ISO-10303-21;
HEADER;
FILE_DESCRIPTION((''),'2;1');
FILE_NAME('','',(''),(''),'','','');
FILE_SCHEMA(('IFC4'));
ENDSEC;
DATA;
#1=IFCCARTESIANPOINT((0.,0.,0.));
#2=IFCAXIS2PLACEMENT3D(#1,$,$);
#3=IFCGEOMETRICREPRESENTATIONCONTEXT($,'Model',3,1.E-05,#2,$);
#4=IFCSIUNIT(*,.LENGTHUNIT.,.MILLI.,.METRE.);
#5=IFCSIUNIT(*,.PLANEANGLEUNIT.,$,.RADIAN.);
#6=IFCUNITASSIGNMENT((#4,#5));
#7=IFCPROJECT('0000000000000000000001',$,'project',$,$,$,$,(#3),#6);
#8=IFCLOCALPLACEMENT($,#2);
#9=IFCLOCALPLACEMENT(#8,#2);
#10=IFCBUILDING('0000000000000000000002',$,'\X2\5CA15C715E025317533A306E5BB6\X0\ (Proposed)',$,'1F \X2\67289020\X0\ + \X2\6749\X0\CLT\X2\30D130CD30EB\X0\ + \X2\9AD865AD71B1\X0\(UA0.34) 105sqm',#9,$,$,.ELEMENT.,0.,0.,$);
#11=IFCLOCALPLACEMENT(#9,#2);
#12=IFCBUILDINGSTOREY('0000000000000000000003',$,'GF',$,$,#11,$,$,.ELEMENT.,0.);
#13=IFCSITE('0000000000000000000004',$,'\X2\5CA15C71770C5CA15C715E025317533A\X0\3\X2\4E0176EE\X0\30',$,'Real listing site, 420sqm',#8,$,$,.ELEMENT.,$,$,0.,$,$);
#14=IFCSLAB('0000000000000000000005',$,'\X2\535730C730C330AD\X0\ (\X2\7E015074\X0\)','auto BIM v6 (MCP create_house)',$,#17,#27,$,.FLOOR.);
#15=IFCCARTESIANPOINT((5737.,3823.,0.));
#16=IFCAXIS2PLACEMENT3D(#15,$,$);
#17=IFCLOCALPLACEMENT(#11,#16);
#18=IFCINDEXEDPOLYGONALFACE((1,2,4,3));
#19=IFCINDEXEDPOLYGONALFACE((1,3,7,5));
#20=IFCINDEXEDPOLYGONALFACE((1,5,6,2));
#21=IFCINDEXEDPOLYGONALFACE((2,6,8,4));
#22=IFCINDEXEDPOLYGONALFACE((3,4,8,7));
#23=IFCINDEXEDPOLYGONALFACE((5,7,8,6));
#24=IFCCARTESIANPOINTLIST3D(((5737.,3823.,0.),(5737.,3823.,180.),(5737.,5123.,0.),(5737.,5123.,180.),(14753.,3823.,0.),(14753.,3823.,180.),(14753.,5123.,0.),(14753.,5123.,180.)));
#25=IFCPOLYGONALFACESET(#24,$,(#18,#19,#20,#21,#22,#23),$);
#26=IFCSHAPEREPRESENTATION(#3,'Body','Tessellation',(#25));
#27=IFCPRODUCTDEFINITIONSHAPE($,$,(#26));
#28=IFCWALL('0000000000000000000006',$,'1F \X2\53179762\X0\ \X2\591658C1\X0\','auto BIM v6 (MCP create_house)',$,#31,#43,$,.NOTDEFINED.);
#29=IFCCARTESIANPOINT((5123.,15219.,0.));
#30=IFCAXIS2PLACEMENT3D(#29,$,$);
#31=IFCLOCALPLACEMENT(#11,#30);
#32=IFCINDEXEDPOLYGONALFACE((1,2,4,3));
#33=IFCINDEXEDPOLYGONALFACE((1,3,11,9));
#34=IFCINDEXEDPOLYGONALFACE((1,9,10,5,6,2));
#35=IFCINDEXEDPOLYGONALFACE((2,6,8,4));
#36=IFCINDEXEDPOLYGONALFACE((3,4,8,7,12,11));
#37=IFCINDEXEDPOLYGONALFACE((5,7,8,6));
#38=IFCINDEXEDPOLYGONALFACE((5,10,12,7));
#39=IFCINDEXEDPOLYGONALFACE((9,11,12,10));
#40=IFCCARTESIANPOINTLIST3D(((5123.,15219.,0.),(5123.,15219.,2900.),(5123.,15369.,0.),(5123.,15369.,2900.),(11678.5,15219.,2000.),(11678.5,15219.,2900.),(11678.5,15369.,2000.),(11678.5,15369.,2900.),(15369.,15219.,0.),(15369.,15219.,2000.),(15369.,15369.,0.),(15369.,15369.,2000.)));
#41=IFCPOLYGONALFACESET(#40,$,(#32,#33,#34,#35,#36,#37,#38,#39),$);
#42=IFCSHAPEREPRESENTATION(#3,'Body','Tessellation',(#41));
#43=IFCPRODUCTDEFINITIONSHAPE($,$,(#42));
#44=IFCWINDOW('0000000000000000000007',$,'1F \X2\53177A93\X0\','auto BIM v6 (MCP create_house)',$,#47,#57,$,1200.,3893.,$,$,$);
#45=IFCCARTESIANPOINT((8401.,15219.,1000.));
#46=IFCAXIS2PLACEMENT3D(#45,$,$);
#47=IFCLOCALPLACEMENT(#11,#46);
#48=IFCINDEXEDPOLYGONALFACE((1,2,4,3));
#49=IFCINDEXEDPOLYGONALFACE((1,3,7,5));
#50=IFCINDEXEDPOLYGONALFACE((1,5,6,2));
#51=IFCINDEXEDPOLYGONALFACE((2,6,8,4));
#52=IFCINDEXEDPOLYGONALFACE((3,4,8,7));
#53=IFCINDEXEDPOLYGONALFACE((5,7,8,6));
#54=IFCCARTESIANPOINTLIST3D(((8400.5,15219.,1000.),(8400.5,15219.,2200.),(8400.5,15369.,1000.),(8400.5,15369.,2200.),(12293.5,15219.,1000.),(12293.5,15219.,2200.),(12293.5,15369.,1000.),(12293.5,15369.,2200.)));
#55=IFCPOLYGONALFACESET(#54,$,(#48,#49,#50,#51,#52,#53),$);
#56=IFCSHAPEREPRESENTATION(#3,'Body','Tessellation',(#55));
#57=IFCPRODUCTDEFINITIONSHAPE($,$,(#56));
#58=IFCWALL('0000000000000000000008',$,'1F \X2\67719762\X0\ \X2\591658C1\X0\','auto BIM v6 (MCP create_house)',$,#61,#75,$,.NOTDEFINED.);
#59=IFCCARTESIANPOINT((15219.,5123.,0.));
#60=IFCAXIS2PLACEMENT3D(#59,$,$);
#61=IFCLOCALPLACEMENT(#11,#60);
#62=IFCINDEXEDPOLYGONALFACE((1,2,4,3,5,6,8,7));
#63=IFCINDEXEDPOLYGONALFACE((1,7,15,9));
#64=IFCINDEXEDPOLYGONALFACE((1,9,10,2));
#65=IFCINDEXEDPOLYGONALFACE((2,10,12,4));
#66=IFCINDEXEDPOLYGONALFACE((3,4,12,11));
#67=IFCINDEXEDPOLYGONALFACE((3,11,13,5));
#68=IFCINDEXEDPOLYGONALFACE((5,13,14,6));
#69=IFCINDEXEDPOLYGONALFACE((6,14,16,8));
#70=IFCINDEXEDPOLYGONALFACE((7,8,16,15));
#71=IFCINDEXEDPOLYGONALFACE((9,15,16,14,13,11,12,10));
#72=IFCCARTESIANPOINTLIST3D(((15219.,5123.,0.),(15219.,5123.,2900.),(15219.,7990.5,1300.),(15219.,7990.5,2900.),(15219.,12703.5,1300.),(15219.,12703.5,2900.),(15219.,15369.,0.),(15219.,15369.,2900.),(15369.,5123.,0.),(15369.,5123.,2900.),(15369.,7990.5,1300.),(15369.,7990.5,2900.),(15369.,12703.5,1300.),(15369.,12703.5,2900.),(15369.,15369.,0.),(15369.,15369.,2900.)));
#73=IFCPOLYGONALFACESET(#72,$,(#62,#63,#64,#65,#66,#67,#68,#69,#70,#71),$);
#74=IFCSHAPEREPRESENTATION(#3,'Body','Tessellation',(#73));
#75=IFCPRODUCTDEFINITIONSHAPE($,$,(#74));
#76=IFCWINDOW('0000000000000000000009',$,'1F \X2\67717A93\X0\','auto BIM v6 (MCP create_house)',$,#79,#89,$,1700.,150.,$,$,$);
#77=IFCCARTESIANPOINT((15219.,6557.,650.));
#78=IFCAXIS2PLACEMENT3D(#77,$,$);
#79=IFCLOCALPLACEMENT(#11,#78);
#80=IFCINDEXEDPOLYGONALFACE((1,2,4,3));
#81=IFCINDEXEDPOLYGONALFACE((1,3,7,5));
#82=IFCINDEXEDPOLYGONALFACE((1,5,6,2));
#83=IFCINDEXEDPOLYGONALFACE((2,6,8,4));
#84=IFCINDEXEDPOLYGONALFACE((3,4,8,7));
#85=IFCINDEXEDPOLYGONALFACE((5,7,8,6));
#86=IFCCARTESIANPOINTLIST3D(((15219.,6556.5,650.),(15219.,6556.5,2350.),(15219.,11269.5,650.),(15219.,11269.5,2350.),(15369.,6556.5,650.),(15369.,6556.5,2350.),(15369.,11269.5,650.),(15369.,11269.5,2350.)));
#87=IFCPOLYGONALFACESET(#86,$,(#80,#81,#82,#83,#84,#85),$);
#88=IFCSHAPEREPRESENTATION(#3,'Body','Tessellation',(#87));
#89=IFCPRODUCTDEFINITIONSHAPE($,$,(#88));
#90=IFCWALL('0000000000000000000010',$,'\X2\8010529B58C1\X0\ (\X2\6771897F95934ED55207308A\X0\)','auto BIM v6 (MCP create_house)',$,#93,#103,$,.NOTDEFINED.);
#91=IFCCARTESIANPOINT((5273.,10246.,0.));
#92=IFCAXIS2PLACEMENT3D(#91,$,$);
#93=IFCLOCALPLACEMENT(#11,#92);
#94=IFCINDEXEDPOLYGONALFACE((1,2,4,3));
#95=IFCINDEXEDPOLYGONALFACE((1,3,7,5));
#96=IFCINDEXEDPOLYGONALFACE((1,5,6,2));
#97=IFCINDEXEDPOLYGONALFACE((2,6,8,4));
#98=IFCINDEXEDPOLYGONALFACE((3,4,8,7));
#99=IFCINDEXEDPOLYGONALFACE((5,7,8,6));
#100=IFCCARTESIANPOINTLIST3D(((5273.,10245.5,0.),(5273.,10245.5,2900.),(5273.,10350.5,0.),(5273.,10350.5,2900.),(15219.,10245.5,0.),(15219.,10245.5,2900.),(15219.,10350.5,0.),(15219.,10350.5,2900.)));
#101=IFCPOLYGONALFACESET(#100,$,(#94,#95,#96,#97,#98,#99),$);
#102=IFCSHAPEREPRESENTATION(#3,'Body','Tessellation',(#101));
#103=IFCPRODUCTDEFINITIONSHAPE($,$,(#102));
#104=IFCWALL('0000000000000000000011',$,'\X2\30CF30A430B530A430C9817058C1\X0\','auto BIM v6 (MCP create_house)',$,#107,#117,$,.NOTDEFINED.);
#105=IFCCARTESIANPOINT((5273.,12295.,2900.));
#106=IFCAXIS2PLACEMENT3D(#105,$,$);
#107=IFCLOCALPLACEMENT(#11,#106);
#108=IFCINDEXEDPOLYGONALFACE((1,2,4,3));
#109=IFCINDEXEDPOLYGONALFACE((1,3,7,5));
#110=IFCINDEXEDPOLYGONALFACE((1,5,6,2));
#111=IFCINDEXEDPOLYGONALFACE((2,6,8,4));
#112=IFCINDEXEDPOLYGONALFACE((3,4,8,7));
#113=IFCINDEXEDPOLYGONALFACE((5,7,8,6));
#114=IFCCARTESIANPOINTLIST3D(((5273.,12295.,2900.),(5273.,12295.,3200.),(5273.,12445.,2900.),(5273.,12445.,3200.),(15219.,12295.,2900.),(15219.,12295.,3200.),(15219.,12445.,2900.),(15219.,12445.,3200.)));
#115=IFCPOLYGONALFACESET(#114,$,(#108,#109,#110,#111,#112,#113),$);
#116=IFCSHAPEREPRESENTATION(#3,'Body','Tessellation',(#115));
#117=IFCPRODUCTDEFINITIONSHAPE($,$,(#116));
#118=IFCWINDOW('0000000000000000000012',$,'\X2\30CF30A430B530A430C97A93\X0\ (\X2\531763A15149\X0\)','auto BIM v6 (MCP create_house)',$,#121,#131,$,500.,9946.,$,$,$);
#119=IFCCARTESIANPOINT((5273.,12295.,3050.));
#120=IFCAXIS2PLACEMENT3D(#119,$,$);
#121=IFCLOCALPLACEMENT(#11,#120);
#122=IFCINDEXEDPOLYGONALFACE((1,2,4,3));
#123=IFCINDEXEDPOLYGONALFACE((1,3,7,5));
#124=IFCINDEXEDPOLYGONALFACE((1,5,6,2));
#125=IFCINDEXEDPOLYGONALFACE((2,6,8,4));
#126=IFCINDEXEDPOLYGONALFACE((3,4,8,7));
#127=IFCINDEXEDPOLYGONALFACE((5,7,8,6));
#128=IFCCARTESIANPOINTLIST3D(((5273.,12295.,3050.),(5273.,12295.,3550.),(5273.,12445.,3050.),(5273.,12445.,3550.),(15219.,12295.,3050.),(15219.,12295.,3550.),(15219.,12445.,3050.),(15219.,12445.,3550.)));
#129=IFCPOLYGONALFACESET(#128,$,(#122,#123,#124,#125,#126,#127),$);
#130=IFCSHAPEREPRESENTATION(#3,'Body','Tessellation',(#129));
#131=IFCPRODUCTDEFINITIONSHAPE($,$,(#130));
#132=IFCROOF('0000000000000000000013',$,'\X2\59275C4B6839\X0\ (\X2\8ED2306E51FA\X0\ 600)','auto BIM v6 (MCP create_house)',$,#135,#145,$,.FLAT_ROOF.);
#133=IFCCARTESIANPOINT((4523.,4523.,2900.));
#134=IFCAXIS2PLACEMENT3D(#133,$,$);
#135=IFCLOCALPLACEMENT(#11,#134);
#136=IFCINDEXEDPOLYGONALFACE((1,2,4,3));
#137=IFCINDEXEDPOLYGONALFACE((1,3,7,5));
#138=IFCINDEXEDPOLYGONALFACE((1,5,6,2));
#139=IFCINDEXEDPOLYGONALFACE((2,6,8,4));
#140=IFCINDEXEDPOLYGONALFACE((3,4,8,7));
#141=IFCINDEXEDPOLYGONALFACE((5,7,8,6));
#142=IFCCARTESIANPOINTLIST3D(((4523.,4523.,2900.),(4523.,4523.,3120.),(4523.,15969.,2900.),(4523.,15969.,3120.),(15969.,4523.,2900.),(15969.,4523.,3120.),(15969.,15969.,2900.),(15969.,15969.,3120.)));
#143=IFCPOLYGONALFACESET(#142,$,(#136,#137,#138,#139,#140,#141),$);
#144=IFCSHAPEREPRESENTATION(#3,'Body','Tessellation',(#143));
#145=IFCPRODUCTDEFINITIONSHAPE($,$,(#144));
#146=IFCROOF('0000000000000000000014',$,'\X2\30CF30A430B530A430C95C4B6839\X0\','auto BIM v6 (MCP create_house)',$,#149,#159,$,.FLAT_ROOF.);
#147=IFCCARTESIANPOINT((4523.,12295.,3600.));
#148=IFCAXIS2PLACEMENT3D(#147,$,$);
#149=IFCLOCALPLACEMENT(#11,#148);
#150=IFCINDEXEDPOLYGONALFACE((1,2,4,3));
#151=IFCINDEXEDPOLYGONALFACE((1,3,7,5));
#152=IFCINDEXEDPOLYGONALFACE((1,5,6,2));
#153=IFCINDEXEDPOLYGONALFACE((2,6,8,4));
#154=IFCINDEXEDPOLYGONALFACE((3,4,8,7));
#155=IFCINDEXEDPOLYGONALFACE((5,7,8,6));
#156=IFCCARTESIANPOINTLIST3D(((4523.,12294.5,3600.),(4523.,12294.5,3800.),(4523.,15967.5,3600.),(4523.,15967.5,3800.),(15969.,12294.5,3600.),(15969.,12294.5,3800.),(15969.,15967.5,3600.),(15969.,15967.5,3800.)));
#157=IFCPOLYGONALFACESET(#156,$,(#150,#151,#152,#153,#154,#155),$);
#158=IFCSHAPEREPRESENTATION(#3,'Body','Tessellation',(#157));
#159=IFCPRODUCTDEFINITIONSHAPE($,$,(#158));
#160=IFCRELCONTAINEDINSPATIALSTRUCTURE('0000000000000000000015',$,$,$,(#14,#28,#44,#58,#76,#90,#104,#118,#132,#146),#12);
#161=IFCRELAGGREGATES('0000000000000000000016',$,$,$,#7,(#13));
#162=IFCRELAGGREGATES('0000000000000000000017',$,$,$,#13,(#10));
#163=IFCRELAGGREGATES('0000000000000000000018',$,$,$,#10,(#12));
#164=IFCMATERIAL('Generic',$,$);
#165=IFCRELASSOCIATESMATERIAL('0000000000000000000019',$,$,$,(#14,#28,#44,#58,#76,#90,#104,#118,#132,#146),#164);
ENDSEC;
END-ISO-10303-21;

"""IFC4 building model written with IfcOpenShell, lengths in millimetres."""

from ifc_helpers import new_model, si_unit, frame, frame_2d, origin, place, context, project, spatial, rectangle, extrude, material, element, fill, save


model = new_model("IFC4")

# Units and contexts
model_context = context("Model", 3, precision=1e-05, world=origin())
ifc_project = project(units=[si_unit("LENGTHUNIT", "METRE", prefix="MILLI"), si_unit("PLANEANGLEUNIT", "RADIAN")], contexts=[model_context])

# Site, building, storey
site_placement = place(None, origin())
site = spatial("IfcSite", under=ifc_project, at=site_placement, Name="岡山県岡山市北区3丁目30", ObjectType="Real listing site, 420sqm", CompositionType="ELEMENT", RefElevation=0.0)
building_placement = place(site_placement, origin())
building = spatial("IfcBuilding", under=site, at=building_placement, Name="岡山市北区の家 (Proposed)", ObjectType="1F 木造 + 杉CLTパネル + 高断熱(UA0.34) 105sqm", CompositionType="ELEMENT", ElevationOfRefHeight=0.0, ElevationOfTerrain=0.0)
storey_placement = place(building_placement, origin())
storey = spatial("IfcBuildingStorey", under=building, at=storey_placement, Name="GF", CompositionType="ELEMENT", Elevation=0.0)

# Slab
ifc_material = material(Name="Generic")
slab_1_placement = place(storey_placement, frame((5737.0, 3823.0, 0.0)))
element("IfcSlab", 1, at=slab_1_placement, inside=storey, material=ifc_material, Name="南デッキ (縁側)", Description="auto BIM v6 (MCP create_house)", PredefinedType="FLOOR", context=model_context, shape_type="SweptSolid", body=[
    extrude(rectangle(XDim=9016.0, YDim=1300.0, at=frame_2d((4508.0, 650.0))), frame((5737.0, 3823.0, 0.0)), (0.0, 0.0, 1.0), 180.0),
])

# Walls, openings, windows
wall_1_placement = place(storey_placement, frame((5123.0, 15219.0, 0.0)))
wall_1 = element("IfcWall", 2, at=wall_1_placement, inside=storey, material=ifc_material, Name="1F 北面 外壁", Description="auto BIM v6 (MCP create_house)", PredefinedType="NOTDEFINED", context=model_context, shape_type="SweptSolid", body=[
    extrude(rectangle(XDim=10246.0, YDim=150.0, at=frame_2d((5123.0, 75.0))), frame((5123.0, 15219.0, 0.0)), (0.0, 0.0, 1.0), 2900.0),
])
opening_1_placement = place(storey_placement, frame((8401.0, 15219.0, 1000.0)))
opening_1 = element("IfcOpeningElement", 3, at=opening_1_placement, cuts=wall_1, PredefinedType="NOTDEFINED", context=model_context, shape_type="SweptSolid", body=[
    extrude(rectangle(XDim=3893.0, YDim=150.0, at=frame_2d((1946.0, 75.0))), frame((8401.0, 15219.0, 1000.0)), (0.0, 0.0, 1.0), 1200.0),
])
window_1_placement = place(storey_placement, frame((8401.0, 15219.0, 1000.0)))
window_1 = element("IfcWindow", 4, at=window_1_placement, inside=storey, material=ifc_material, Name="1F 北窓", Description="auto BIM v6 (MCP create_house)", OverallHeight=1200.0, OverallWidth=3893.0, context=model_context, shape_type="SweptSolid", body=[
    extrude(rectangle(XDim=3893.0, YDim=150.0, at=frame_2d((1946.0, 75.0))), frame((8401.0, 15219.0, 1000.0)), (0.0, 0.0, 1.0), 1200.0),
])
fill(opening_1, window_1)
wall_2_placement = place(storey_placement, frame((15219.0, 5123.0, 0.0)))
wall_2 = element("IfcWall", 5, at=wall_2_placement, inside=storey, material=ifc_material, Name="1F 東面 外壁", Description="auto BIM v6 (MCP create_house)", PredefinedType="NOTDEFINED", context=model_context, shape_type="SweptSolid", body=[
    extrude(rectangle(XDim=150.0, YDim=10246.0, at=frame_2d((75.0, 5123.0))), frame((15219.0, 5123.0, 0.0)), (0.0, 0.0, 1.0), 2900.0),
])
opening_2_placement = place(storey_placement, frame((15219.0, 6557.0, 650.0)))
opening_2 = element("IfcOpeningElement", 6, at=opening_2_placement, cuts=wall_2, PredefinedType="NOTDEFINED", context=model_context, shape_type="SweptSolid", body=[
    extrude(rectangle(XDim=150.0, YDim=4713.0, at=frame_2d((75.0, 2356.0))), frame((15219.0, 6557.0, 650.0)), (0.0, 0.0, 1.0), 1700.0),
])
window_2_placement = place(storey_placement, frame((15219.0, 6557.0, 650.0)))
window_2 = element("IfcWindow", 7, at=window_2_placement, inside=storey, material=ifc_material, Name="1F 東窓", Description="auto BIM v6 (MCP create_house)", OverallHeight=1700.0, OverallWidth=150.0, context=model_context, shape_type="SweptSolid", body=[
    extrude(rectangle(XDim=150.0, YDim=4713.0, at=frame_2d((75.0, 2356.0))), frame((15219.0, 6557.0, 650.0)), (0.0, 0.0, 1.0), 1700.0),
])
fill(opening_2, window_2)

# Wall
wall_3_placement = place(storey_placement, frame((5273.0, 10246.0, 0.0)))
element("IfcWall", 8, at=wall_3_placement, inside=storey, material=ifc_material, Name="耐力壁 (東西間仕切り)", Description="auto BIM v6 (MCP create_house)", PredefinedType="NOTDEFINED", context=model_context, shape_type="SweptSolid", body=[
    extrude(rectangle(XDim=9946.0, YDim=105.0, at=frame_2d((4973.0, 52.0))), frame((5273.0, 10246.0, 0.0)), (0.0, 0.0, 1.0), 2900.0),
])

# Wall, opening, window
wall_4_placement = place(storey_placement, frame((5273.0, 12295.0, 2900.0)))
wall_4 = element("IfcWall", 9, at=wall_4_placement, inside=storey, material=ifc_material, Name="ハイサイド腰壁", Description="auto BIM v6 (MCP create_house)", PredefinedType="NOTDEFINED", context=model_context, shape_type="SweptSolid", body=[
    extrude(rectangle(XDim=9946.0, YDim=150.0, at=frame_2d((4973.0, 75.0))), frame((5273.0, 12295.0, 2900.0)), (0.0, 0.0, 1.0), 700.0),
])
opening_3_placement = place(storey_placement, frame((5273.0, 12295.0, 3050.0)))
opening_3 = element("IfcOpeningElement", 10, at=opening_3_placement, cuts=wall_4, PredefinedType="NOTDEFINED", context=model_context, shape_type="SweptSolid", body=[
    extrude(rectangle(XDim=9946.0, YDim=150.0, at=frame_2d((4973.0, 75.0))), frame((5273.0, 12295.0, 3050.0)), (0.0, 0.0, 1.0), 500.0),
])
window_3_placement = place(storey_placement, frame((5273.0, 12295.0, 3050.0)))
window_3 = element("IfcWindow", 11, at=window_3_placement, inside=storey, material=ifc_material, Name="ハイサイド窓 (北採光)", Description="auto BIM v6 (MCP create_house)", OverallHeight=500.0, OverallWidth=9946.0, context=model_context, shape_type="SweptSolid", body=[
    extrude(rectangle(XDim=9946.0, YDim=150.0, at=frame_2d((4973.0, 75.0))), frame((5273.0, 12295.0, 3050.0)), (0.0, 0.0, 1.0), 500.0),
])
fill(opening_3, window_3)

# Roofs
roof_1_placement = place(storey_placement, frame((4523.0, 4523.0, 2900.0)))
element("IfcRoof", 12, at=roof_1_placement, inside=storey, material=ifc_material, Name="大屋根 (軒の出 600)", Description="auto BIM v6 (MCP create_house)", PredefinedType="FLAT_ROOF", context=model_context, shape_type="SweptSolid", body=[
    extrude(rectangle(XDim=11446.0, YDim=11446.0, at=frame_2d((5723.0, 5723.0))), frame((4523.0, 4523.0, 2900.0)), (0.0, 0.0, 1.0), 220.0),
])
roof_2_placement = place(storey_placement, frame((4523.0, 12295.0, 3600.0)))
element("IfcRoof", 13, at=roof_2_placement, inside=storey, material=ifc_material, Name="ハイサイド屋根", Description="auto BIM v6 (MCP create_house)", PredefinedType="FLAT_ROOF", context=model_context, shape_type="SweptSolid", body=[
    extrude(rectangle(XDim=11446.0, YDim=3673.0, at=frame_2d((5723.0, 1836.0))), frame((4523.0, 12295.0, 3600.0)), (0.0, 0.0, 1.0), 200.0),
])

save(model, "model.ifc")
